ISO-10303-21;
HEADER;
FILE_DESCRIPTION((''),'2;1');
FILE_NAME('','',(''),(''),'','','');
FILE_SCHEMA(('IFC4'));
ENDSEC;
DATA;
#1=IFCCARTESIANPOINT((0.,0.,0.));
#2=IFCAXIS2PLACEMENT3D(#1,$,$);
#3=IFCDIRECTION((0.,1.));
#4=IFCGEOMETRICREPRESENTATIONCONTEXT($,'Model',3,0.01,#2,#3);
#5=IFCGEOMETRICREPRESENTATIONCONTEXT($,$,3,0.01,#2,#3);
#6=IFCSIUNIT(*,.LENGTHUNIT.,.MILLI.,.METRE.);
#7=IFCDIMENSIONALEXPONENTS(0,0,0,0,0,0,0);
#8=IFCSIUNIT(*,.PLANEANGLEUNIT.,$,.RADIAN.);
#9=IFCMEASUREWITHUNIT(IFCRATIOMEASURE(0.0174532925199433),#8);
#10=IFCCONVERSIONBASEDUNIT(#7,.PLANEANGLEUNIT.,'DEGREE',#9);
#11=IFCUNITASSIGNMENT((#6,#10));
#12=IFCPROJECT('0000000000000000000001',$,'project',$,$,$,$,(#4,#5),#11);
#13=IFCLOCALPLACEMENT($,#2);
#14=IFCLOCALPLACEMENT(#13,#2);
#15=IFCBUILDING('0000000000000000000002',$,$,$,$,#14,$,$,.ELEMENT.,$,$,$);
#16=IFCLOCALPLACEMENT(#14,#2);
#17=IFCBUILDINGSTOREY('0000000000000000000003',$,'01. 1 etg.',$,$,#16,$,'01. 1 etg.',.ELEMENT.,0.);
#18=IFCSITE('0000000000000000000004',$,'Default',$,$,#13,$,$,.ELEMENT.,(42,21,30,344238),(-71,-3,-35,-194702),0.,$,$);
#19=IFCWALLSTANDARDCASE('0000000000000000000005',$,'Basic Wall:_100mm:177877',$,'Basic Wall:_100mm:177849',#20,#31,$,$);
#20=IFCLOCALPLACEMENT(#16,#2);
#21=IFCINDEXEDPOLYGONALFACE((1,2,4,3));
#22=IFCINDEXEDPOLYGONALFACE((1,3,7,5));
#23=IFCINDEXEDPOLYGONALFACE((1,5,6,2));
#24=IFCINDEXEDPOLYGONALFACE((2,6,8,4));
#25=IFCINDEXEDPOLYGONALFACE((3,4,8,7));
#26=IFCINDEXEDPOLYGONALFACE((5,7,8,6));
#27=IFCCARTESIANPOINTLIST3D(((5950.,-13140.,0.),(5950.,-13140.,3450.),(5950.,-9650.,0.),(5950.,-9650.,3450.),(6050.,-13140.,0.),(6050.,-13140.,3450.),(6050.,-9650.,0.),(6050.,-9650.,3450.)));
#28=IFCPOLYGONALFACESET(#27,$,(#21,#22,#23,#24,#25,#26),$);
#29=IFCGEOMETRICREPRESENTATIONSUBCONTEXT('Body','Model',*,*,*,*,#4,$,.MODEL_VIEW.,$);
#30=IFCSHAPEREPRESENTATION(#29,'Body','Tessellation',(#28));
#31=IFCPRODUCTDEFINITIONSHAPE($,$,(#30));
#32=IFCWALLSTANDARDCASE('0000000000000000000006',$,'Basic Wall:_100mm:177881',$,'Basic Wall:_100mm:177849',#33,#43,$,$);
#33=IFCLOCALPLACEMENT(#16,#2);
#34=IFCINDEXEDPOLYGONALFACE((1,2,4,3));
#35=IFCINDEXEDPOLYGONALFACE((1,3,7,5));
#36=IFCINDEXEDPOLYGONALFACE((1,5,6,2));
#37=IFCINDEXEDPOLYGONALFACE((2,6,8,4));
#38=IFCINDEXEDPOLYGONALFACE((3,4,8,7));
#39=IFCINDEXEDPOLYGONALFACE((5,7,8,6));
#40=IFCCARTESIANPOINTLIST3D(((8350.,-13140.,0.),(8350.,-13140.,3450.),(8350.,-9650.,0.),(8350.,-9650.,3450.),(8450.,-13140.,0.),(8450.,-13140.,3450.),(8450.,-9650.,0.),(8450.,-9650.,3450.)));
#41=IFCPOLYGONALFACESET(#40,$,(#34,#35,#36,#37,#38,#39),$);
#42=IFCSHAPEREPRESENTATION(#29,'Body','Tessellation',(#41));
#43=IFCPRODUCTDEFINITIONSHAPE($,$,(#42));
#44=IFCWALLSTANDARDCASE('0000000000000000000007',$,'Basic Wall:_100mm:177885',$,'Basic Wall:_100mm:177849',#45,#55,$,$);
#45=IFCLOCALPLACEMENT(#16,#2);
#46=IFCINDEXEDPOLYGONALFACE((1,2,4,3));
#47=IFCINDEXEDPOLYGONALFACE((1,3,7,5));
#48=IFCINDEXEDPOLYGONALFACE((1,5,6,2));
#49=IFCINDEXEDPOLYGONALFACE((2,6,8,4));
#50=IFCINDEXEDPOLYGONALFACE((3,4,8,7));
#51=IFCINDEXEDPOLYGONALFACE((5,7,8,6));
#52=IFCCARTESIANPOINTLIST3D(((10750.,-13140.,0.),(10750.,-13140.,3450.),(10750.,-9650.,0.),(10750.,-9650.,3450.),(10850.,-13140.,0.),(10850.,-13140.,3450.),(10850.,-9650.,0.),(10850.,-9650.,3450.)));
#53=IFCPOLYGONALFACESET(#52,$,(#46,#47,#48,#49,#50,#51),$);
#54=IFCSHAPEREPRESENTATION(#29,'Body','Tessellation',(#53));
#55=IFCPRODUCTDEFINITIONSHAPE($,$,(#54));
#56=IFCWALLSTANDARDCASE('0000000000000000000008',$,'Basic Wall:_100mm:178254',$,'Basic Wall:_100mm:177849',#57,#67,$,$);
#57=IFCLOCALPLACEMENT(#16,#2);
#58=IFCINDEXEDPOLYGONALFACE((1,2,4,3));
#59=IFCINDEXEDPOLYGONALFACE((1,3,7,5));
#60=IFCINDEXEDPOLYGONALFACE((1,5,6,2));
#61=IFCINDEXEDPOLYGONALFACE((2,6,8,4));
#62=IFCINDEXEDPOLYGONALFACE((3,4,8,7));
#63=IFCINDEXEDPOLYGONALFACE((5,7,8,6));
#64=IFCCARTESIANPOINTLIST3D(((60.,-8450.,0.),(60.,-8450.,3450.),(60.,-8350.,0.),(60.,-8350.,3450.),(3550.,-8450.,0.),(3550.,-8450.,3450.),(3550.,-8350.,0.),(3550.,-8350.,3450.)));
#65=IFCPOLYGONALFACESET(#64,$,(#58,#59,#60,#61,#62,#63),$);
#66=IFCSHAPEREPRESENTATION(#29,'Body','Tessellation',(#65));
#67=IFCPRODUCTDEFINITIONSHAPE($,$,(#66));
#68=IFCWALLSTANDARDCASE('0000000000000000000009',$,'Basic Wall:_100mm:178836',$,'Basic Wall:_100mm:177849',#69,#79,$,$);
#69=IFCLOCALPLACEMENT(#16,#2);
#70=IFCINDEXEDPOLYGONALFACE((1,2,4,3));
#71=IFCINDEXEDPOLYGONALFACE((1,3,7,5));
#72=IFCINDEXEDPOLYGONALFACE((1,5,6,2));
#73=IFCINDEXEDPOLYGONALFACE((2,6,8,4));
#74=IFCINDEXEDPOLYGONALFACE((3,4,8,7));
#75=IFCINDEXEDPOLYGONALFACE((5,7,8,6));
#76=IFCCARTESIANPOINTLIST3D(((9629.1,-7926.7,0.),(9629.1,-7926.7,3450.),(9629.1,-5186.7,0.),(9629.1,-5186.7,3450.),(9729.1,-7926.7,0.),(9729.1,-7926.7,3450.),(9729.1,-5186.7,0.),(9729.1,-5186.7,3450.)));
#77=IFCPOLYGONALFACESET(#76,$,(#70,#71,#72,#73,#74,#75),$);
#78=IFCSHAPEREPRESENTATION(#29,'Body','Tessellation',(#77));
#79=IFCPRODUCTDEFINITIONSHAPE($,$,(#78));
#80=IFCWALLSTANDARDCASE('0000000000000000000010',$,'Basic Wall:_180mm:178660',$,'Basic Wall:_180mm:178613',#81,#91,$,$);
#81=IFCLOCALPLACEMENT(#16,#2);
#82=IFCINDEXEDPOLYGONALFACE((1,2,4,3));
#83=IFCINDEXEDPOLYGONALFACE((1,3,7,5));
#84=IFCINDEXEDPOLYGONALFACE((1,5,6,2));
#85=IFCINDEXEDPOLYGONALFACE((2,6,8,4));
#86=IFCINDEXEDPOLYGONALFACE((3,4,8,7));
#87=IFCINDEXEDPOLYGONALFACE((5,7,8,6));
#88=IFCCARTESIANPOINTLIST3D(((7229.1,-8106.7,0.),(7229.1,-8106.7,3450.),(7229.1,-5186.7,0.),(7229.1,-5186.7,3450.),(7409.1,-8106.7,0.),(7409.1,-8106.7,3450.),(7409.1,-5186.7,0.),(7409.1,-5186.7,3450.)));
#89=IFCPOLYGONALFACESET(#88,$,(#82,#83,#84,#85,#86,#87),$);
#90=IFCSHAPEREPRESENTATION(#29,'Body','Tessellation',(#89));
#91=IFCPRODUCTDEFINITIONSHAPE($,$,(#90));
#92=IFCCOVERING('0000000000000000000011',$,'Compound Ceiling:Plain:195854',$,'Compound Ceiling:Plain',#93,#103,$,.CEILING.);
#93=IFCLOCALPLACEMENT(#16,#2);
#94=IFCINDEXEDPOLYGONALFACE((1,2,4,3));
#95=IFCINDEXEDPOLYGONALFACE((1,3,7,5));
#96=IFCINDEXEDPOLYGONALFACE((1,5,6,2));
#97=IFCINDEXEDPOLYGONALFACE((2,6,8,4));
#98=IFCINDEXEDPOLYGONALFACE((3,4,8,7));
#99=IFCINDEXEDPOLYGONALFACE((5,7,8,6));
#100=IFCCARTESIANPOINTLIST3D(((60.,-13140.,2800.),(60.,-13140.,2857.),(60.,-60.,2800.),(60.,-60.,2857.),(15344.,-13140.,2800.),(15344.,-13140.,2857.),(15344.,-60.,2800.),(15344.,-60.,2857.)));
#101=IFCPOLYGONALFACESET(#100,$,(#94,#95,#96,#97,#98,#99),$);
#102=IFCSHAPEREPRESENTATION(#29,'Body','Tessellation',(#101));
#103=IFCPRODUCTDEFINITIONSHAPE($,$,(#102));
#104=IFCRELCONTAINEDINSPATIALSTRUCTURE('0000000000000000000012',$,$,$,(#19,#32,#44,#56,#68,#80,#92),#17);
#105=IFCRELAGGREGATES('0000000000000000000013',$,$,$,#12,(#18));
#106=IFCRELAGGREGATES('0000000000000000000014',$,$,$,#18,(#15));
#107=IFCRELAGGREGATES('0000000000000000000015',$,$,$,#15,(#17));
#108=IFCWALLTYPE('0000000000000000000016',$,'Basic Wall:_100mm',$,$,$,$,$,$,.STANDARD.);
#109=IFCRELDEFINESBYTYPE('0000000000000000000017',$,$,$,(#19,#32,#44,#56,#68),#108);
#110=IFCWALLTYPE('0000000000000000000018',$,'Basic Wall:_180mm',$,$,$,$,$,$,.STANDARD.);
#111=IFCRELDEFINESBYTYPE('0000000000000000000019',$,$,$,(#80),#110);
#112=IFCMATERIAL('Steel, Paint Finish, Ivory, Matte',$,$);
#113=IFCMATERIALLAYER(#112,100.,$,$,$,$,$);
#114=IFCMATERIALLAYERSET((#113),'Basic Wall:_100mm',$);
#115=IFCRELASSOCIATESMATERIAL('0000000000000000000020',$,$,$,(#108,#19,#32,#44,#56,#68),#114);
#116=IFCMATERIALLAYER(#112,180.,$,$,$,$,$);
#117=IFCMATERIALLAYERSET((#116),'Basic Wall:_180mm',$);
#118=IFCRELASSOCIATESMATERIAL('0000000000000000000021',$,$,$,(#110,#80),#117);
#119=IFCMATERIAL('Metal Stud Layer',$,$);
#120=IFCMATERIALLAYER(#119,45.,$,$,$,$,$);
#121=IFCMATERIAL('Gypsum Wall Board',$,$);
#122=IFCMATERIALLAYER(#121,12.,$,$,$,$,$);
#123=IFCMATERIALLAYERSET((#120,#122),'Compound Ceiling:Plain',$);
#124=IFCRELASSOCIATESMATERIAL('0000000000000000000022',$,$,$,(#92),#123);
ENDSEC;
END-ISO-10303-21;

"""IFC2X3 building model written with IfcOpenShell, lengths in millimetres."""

from ifc_helpers import new_model, entity, si_unit, converted_unit, direction, frame, frame_2d, origin, place, context, subcontext, project, spatial, polyline, rectangle, extrude, clip, bounded_halfspace, material, layer, layer_set, layer_usage, type_object, element, save


model = new_model("IFC2X3")

# Units and contexts
model_context = context("Model", 3, precision=0.01, world=origin(), true_north=direction((0.0, 1.0)))
context_of_model = context(None, 3, precision=0.01, world=origin(), true_north=direction((0.0, 1.0)))
body_context = subcontext(model_context, "Body", "Model", "MODEL_VIEW")
ifc_project = project(units=[si_unit("LENGTHUNIT", "METRE", prefix="MILLI"), converted_unit("PLANEANGLEUNIT", "DEGREE", entity("IfcRatioMeasure", 0.0174532925199433), si_unit("PLANEANGLEUNIT", "RADIAN"), dimensions=[0, 0, 0, 0, 0, 0, 0])], contexts=[model_context, context_of_model])

# Site, building, storey
site_placement = place(None, origin())
site = spatial("IfcSite", under=ifc_project, at=site_placement, Name="Default", CompositionType="ELEMENT", RefLatitude=(42, 21, 30, 344238), RefLongitude=(-71, -3, -35, -194702), RefElevation=0.0)
building_placement = place(site_placement, origin())
building = spatial("IfcBuilding", under=site, at=building_placement, CompositionType="ELEMENT")
storey_placement = place(building_placement, origin())
storey = spatial("IfcBuildingStorey", under=building, at=storey_placement, Name="01. 1 etg.", LongName="01. 1 etg.", CompositionType="ELEMENT", Elevation=0.0)

# Shared definitions
ifc_material_1 = material(Name="Steel, Paint Finish, Ivory, Matte")
ifc_layer_1 = layer(ifc_material_1, 100.0)
ifc_layer_set_1 = layer_set([ifc_layer_1], Name="Basic Wall:_100mm")
wall_type_1 = type_object("IfcWallType", Name="Basic Wall:_100mm", PredefinedType="STANDARD", material=ifc_layer_set_1)

# Walls
ifc_layer_usage_1 = layer_usage(ifc_layer_set_1, "AXIS2", "NEGATIVE", 50.0)
wall_1_placement = place(storey_placement, frame((6000.0, -13140.0, 0.0), z_axis=(0.0, 0.0, 1.0), x_axis=(0.0, 1.0, 0.0)))
element("IfcWallStandardCase", 1, at=wall_1_placement, inside=storey, type_object=wall_type_1, material=ifc_layer_usage_1, Name="Basic Wall:_100mm:177877", ObjectType="Basic Wall:_100mm:177849", context=body_context, shape_type="Clipping", body=[
    clip(extrude(rectangle(XDim=3490.0, YDim=100.0, at=frame_2d((1745.0, 0.0), x_axis=(-1.0, 0.0))), origin(), (0.0, 0.0, 1.0), 3450.0), bounded_halfspace(frame((0.0, -50.0, 3450.0), z_axis=(0.0, 0.0, -1.0), x_axis=(-1.0, 0.0, 0.0)), True, frame((0.0, -50.0, 3450.0)), polyline([(0.0, 0.0), (3490.0, 0.0), (3490.0, 100.0), (0.0, 100.0), (0.0, 0.0)]))),
])
ifc_layer_usage_2 = layer_usage(ifc_layer_set_1, "AXIS2", "NEGATIVE", 50.0)
wall_2_placement = place(storey_placement, frame((8400.0, -13140.0, 0.0), z_axis=(0.0, 0.0, 1.0), x_axis=(0.0, 1.0, 0.0)))
element("IfcWallStandardCase", 2, at=wall_2_placement, inside=storey, type_object=wall_type_1, material=ifc_layer_usage_2, Name="Basic Wall:_100mm:177881", ObjectType="Basic Wall:_100mm:177849", context=body_context, shape_type="Clipping", body=[
    clip(extrude(rectangle(XDim=3490.0, YDim=100.0, at=frame_2d((1745.0, 0.0), x_axis=(-1.0, 0.0))), origin(), (0.0, 0.0, 1.0), 3450.0), bounded_halfspace(frame((0.0, -50.0, 3450.0), z_axis=(0.0, 0.0, -1.0), x_axis=(-1.0, 0.0, 0.0)), True, frame((0.0, -50.0, 3450.0)), polyline([(0.0, 0.0), (3490.0, 0.0), (3490.0, 100.0), (0.0, 100.0), (0.0, 0.0)]))),
])
ifc_layer_usage_3 = layer_usage(ifc_layer_set_1, "AXIS2", "NEGATIVE", 50.0)
wall_3_placement = place(storey_placement, frame((10800.0, -13140.0, 0.0), z_axis=(0.0, 0.0, 1.0), x_axis=(0.0, 1.0, 0.0)))
element("IfcWallStandardCase", 3, at=wall_3_placement, inside=storey, type_object=wall_type_1, material=ifc_layer_usage_3, Name="Basic Wall:_100mm:177885", ObjectType="Basic Wall:_100mm:177849", context=body_context, shape_type="Clipping", body=[
    clip(extrude(rectangle(XDim=3490.0, YDim=100.0, at=frame_2d((1745.0, 0.0), x_axis=(-1.0, 0.0))), origin(), (0.0, 0.0, 1.0), 3450.0), bounded_halfspace(frame((0.0, -50.0, 3450.0), z_axis=(0.0, 0.0, -1.0), x_axis=(-1.0, 0.0, 0.0)), True, frame((0.0, -50.0, 3450.0)), polyline([(0.0, 0.0), (3490.0, 0.0), (3490.0, 100.0), (0.0, 100.0), (0.0, 0.0)]))),
])
ifc_layer_usage_4 = layer_usage(ifc_layer_set_1, "AXIS2", "NEGATIVE", 50.0)
wall_4_placement = place(storey_placement, frame((3550.0, -8400.0, 0.0), z_axis=(0.0, 0.0, 1.0), x_axis=(-1.0, 0.0, 0.0)))
element("IfcWallStandardCase", 4, at=wall_4_placement, inside=storey, type_object=wall_type_1, material=ifc_layer_usage_4, Name="Basic Wall:_100mm:178254", ObjectType="Basic Wall:_100mm:177849", context=body_context, shape_type="Clipping", body=[
    clip(extrude(rectangle(XDim=3490.0, YDim=100.0, at=frame_2d((1745.0, 0.0), x_axis=(-1.0, 0.0))), origin(), (0.0, 0.0, 1.0), 3450.0), bounded_halfspace(frame((0.0, -50.0, 3450.0), z_axis=(0.0, 0.0, -1.0), x_axis=(0.0, 1.0, 0.0)), True, frame((0.0, -50.0, 3450.0)), polyline([(0.0, 0.0), (3490.0, 0.0), (3490.0, 100.0), (0.0, 100.0), (0.0, 0.0)]))),
])
ifc_layer_usage_5 = layer_usage(ifc_layer_set_1, "AXIS2", "POSITIVE", -50.0)
wall_5_placement = place(storey_placement, frame((9679.1, -5186.7, 0.0), z_axis=(0.0, 0.0, 1.0), x_axis=(0.0, -1.0, 0.0)))
element("IfcWallStandardCase", 5, at=wall_5_placement, inside=storey, type_object=wall_type_1, material=ifc_layer_usage_5, Name="Basic Wall:_100mm:178836", ObjectType="Basic Wall:_100mm:177849", context=body_context, shape_type="Clipping", body=[
    clip(extrude(rectangle(XDim=2740.0, YDim=100.0, at=frame_2d((1370.0, 0.0), x_axis=(-1.0, 0.0))), origin(), (0.0, 0.0, 1.0), 3450.0), bounded_halfspace(frame((0.0, -50.0, 3450.0), z_axis=(0.0, 0.0, -1.0), x_axis=(1.0, 0.0, 0.0)), True, frame((0.0, -50.0, 3450.0)), polyline([(0.0, 0.0), (2740.0, 0.0), (2740.0, 100.0), (0.0, 100.0), (0.0, 0.0)]))),
])
ifc_layer_2 = layer(ifc_material_1, 180.0)
ifc_layer_set_2 = layer_set([ifc_layer_2], Name="Basic Wall:_180mm")
ifc_layer_usage_6 = layer_usage(ifc_layer_set_2, "AXIS2", "NEGATIVE", 90.0)
wall_type_2 = type_object("IfcWallType", Name="Basic Wall:_180mm", PredefinedType="STANDARD", material=ifc_layer_set_2)
wall_6_placement = place(storey_placement, frame((7319.1, -8106.7, 0.0), z_axis=(0.0, 0.0, 1.0), x_axis=(0.0, 1.0, 0.0)))
element("IfcWallStandardCase", 6, at=wall_6_placement, inside=storey, type_object=wall_type_2, material=ifc_layer_usage_6, Name="Basic Wall:_180mm:178660", ObjectType="Basic Wall:_180mm:178613", context=body_context, shape_type="Clipping", body=[
    clip(extrude(rectangle(XDim=2920.0, YDim=180.0, at=frame_2d((1460.0, 0.0), x_axis=(-1.0, 0.0))), origin(), (0.0, 0.0, 1.0), 3450.0), bounded_halfspace(frame((0.0, -90.0, 3450.0), z_axis=(0.0, 0.0, -1.0), x_axis=(-1.0, 0.0, 0.0)), True, frame((0.0, -90.0, 3450.0)), polyline([(0.0, 0.0), (180.0, 0.0), (2920.0, 0.0), (2920.0, 180.0), (0.0, 180.0), (0.0, 0.0)]))),
])

# Covering
ifc_material_2 = material(Name="Metal Stud Layer")
ifc_layer_3 = layer(ifc_material_2, 45.0)
ifc_material_3 = material(Name="Gypsum Wall Board")
ifc_layer_4 = layer(ifc_material_3, 12.0)
ifc_layer_set_3 = layer_set([ifc_layer_3, ifc_layer_4], Name="Compound Ceiling:Plain")
ifc_layer_usage_7 = layer_usage(ifc_layer_set_3, "AXIS3", "NEGATIVE", 0.0)
covering_placement = place(storey_placement, frame((60.0, -13140.0, 2800.0)))
element("IfcCovering", 7, at=covering_placement, inside=storey, material=ifc_layer_usage_7, Name="Compound Ceiling:Plain:195854", ObjectType="Compound Ceiling:Plain", PredefinedType="CEILING", context=body_context, shape_type="SweptSolid", body=[
    extrude(rectangle(XDim=13080.0, YDim=15284.0, at=frame_2d((0.0, 0.0), x_axis=(1.0, 0.0))), frame((7642.0, 6540.0, 0.0), z_axis=(0.0, 0.0, 1.0), x_axis=(0.0, -1.0, 0.0)), (0.0, 0.0, 1.0), 57.0),
])

save(model, "model.ifc")
